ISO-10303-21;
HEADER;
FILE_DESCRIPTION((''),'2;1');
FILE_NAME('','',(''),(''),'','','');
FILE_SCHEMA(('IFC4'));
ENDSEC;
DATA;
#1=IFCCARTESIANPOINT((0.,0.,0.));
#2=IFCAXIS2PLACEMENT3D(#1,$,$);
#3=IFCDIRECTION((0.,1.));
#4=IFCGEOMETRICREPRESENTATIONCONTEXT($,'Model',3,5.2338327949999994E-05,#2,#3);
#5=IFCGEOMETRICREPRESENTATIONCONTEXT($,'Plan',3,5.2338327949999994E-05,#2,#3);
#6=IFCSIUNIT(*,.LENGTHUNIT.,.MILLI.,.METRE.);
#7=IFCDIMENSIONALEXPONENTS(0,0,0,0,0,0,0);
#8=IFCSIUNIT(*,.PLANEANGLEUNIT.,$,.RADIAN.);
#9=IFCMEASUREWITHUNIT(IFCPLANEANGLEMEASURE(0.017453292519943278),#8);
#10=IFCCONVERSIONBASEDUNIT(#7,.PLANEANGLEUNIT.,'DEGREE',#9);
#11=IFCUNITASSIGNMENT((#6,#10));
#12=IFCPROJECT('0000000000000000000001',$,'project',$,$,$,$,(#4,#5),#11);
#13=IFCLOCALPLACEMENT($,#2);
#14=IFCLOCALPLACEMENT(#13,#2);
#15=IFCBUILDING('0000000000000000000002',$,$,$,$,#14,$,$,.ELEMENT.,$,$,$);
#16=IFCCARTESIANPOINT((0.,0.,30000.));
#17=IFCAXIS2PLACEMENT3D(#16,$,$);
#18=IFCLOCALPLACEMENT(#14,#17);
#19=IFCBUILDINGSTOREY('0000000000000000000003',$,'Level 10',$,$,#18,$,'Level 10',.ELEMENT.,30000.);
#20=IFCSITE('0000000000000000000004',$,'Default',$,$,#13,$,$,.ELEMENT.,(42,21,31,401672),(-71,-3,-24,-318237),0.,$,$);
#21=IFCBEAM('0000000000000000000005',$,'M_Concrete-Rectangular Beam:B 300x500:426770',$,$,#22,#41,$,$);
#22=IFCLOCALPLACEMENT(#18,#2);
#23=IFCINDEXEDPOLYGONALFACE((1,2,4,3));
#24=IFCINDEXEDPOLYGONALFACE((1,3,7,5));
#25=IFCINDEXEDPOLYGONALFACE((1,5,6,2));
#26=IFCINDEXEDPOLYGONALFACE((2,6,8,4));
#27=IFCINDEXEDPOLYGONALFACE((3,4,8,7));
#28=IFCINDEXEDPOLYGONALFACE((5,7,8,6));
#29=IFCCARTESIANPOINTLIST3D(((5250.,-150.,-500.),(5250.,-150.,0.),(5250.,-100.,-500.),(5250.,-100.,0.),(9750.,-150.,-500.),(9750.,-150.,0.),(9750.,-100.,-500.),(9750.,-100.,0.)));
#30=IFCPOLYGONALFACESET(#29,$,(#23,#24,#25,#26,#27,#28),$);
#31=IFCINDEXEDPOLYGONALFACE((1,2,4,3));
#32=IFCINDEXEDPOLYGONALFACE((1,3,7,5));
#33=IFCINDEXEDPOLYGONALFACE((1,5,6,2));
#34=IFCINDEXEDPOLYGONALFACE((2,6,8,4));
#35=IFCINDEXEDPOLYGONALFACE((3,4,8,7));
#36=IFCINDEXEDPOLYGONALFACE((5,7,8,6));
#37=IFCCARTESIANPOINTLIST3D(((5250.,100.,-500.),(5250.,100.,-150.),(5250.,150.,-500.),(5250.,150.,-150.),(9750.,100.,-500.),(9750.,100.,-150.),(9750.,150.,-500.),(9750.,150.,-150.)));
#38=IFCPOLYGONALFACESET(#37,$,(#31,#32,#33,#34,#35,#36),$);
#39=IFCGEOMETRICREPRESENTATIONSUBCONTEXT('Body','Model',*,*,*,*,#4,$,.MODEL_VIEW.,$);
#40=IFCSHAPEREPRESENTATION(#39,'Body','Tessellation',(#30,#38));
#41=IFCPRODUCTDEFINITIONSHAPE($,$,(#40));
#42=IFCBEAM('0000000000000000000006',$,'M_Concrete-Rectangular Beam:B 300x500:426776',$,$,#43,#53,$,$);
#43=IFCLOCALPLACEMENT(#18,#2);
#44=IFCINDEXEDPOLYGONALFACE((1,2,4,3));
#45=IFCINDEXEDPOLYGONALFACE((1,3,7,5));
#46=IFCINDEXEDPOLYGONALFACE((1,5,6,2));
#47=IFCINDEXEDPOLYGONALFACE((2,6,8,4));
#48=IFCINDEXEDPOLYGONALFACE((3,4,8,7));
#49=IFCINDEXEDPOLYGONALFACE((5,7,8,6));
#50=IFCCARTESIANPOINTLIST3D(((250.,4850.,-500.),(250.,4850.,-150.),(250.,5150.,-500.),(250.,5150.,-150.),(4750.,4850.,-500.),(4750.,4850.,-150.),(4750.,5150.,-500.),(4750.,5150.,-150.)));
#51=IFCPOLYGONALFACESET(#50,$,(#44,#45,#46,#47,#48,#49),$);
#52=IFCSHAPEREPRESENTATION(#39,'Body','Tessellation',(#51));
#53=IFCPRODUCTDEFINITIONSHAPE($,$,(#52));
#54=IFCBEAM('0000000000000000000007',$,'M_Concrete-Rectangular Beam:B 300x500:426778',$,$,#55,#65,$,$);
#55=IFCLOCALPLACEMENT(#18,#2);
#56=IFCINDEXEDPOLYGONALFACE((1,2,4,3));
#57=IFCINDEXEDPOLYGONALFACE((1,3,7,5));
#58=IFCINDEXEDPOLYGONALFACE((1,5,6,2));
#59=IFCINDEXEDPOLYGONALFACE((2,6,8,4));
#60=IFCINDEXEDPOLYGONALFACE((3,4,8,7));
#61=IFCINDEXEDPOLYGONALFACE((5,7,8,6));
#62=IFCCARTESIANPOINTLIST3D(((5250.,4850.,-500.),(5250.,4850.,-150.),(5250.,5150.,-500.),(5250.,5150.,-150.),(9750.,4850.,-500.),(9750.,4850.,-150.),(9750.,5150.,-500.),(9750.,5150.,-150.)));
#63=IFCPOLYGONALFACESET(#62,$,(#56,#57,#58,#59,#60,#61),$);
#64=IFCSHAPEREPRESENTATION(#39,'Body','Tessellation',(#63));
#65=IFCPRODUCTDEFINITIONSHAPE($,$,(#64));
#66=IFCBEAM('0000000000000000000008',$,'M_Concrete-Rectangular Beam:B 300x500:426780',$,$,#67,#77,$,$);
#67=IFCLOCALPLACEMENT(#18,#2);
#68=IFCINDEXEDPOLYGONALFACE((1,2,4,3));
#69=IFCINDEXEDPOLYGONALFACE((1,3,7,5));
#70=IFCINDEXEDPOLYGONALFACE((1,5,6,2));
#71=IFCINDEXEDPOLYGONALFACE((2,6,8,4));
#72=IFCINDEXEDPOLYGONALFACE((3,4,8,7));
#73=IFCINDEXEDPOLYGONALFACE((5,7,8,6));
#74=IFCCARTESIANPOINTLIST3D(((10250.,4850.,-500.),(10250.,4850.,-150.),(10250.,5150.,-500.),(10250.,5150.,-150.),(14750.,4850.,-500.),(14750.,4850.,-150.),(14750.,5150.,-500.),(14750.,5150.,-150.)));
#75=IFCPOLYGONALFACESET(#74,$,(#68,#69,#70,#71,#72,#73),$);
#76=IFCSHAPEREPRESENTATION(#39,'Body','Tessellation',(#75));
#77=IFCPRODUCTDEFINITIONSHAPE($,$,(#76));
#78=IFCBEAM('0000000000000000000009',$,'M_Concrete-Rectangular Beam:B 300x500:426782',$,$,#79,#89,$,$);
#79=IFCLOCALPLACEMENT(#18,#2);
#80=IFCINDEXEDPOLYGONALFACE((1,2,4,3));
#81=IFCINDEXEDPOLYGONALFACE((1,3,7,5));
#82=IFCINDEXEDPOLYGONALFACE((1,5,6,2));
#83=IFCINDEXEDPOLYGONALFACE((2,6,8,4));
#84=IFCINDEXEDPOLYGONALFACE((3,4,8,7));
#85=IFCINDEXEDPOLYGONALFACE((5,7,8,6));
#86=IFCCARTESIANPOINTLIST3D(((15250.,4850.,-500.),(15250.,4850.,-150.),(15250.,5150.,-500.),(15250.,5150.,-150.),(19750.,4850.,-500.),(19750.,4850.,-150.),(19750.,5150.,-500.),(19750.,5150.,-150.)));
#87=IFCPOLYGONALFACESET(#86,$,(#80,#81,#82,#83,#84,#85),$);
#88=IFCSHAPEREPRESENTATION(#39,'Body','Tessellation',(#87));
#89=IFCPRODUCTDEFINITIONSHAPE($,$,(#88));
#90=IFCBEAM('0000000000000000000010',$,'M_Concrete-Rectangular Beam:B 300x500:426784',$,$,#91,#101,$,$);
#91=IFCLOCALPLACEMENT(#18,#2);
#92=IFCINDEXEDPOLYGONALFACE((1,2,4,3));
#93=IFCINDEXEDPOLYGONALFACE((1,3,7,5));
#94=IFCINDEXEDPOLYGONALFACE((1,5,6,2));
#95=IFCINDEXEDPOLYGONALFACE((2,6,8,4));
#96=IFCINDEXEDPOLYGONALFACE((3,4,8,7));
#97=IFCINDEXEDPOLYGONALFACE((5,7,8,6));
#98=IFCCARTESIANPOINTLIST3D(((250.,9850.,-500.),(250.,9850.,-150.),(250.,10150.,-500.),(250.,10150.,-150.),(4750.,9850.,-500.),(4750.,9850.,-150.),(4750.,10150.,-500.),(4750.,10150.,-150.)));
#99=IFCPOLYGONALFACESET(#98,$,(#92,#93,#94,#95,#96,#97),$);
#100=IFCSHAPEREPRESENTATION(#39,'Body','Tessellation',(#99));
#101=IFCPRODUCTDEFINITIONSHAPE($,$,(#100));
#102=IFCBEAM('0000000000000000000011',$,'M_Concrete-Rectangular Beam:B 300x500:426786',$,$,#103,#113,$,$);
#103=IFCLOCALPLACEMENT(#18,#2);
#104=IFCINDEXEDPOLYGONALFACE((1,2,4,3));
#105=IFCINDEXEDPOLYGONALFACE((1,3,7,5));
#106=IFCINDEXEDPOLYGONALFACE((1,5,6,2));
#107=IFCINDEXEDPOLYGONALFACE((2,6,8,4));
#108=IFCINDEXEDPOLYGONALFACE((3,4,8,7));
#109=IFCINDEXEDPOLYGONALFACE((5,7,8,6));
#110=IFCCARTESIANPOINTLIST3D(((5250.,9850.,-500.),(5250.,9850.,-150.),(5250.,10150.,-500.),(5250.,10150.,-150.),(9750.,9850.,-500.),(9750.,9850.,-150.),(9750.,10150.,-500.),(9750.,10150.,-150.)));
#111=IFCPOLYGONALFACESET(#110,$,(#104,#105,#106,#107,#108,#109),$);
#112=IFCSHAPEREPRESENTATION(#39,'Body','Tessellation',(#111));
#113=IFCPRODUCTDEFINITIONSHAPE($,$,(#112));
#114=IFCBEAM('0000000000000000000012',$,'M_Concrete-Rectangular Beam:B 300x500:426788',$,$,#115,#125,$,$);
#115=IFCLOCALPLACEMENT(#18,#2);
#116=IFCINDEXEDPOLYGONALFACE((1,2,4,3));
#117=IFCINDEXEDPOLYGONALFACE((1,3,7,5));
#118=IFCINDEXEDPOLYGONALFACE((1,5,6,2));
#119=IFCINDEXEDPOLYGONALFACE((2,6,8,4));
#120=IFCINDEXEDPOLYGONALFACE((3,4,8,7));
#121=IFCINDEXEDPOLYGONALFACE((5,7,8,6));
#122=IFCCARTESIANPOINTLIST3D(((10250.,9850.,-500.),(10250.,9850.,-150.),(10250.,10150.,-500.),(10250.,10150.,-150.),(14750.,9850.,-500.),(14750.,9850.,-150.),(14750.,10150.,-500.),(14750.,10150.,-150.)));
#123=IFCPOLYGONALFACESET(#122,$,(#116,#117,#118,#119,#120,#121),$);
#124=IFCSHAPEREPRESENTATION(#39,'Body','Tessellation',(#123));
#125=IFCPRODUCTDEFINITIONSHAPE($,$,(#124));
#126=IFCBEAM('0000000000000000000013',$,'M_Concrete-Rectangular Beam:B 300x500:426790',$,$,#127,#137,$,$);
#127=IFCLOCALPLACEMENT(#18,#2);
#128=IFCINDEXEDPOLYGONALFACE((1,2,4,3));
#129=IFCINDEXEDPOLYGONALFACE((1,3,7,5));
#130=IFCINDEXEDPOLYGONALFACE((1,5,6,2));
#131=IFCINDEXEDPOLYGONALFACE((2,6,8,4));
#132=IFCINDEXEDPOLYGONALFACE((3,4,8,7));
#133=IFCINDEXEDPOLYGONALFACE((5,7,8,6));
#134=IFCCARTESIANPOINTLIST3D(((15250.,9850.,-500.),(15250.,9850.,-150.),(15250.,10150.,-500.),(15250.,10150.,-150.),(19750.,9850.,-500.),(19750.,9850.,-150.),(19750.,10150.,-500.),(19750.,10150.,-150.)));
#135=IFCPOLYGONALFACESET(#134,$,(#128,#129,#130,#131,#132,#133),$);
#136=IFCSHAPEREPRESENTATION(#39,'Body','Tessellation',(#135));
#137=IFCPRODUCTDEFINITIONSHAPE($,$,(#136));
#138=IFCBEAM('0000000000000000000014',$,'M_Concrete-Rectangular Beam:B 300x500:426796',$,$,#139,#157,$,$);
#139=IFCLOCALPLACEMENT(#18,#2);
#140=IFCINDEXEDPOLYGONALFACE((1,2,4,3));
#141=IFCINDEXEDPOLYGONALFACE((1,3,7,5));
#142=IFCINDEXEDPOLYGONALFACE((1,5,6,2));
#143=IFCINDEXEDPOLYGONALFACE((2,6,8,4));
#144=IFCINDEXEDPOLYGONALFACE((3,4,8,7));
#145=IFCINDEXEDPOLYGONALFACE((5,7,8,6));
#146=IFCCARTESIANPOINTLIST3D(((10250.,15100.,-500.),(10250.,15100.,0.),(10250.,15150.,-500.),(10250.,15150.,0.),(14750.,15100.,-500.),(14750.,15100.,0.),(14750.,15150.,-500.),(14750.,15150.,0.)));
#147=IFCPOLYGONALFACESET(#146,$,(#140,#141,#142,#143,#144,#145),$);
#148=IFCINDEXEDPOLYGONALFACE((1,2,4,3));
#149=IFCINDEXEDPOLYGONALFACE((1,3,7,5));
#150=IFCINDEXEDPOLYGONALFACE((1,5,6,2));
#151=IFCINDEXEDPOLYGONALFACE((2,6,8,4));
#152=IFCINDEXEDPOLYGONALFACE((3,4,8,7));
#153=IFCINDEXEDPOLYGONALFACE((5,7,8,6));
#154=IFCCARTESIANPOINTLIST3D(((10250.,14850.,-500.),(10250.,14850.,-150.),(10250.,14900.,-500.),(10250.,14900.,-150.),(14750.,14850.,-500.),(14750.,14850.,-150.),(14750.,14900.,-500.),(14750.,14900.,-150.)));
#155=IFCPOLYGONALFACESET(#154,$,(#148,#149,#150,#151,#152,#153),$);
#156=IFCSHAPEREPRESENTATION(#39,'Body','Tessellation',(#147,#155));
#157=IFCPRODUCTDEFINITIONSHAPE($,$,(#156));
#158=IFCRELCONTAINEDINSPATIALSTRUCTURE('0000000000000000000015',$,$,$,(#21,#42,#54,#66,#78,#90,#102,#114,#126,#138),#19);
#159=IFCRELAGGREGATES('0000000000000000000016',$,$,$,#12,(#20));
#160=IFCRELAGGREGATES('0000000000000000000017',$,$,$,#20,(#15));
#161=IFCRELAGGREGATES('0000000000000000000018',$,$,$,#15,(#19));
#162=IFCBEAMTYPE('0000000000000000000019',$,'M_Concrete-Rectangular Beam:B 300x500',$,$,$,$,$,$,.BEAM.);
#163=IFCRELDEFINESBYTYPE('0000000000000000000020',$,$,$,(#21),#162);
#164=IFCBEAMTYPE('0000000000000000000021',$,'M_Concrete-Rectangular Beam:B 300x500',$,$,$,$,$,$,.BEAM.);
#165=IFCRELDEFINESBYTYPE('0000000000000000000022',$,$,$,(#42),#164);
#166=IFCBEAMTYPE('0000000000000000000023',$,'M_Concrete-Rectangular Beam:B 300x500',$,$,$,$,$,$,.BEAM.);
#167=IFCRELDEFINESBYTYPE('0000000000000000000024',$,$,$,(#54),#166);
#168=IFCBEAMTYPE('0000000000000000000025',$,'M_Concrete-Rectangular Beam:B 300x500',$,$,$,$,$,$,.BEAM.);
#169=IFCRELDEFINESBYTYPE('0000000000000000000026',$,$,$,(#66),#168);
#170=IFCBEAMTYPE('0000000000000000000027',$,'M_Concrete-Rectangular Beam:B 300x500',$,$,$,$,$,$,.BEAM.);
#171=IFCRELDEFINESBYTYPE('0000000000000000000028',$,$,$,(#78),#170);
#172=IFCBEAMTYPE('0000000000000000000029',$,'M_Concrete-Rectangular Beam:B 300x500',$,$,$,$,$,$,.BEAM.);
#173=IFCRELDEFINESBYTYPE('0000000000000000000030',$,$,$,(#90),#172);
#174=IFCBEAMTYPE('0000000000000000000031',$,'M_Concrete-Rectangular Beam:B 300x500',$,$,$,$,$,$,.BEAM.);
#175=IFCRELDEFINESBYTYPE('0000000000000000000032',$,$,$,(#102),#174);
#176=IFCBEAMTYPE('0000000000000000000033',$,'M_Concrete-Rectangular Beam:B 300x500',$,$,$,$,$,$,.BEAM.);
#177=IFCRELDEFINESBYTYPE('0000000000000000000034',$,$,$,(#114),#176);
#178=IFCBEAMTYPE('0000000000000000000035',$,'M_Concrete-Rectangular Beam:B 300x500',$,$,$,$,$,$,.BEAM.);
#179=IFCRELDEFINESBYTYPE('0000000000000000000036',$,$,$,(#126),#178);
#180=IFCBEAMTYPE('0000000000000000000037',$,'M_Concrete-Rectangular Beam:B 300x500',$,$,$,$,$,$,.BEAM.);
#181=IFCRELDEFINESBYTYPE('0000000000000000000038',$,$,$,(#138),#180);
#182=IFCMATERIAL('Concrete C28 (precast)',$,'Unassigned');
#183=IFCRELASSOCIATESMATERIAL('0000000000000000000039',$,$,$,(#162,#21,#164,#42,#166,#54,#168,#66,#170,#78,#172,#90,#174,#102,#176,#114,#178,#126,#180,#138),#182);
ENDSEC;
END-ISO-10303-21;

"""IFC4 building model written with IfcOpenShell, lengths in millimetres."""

from ifc_helpers import new_model, entity, si_unit, converted_unit, direction, frame, origin, place, context, subcontext, project, spatial, indexed_curve, outline, extrude, source, transform, mapped, material, type_object, type_shapes, element, save


model = new_model("IFC4")

# Units and contexts
model_context = context("Model", 3, precision=5.2338327949999994e-05, world=origin(), true_north=direction((0.0, 1.0)))
plan_context = context("Plan", 3, precision=5.2338327949999994e-05, world=origin(), true_north=direction((0.0, 1.0)))
body_context = subcontext(model_context, "Body", "Model", "MODEL_VIEW")
ifc_project = project(units=[si_unit("LENGTHUNIT", "METRE", prefix="MILLI"), converted_unit("PLANEANGLEUNIT", "DEGREE", entity("IfcPlaneAngleMeasure", 0.017453292519943278), si_unit("PLANEANGLEUNIT", "RADIAN"), dimensions=[0, 0, 0, 0, 0, 0, 0])], contexts=[model_context, plan_context])

# Site, building, storey
site_placement = place(None, origin())
site = spatial("IfcSite", under=ifc_project, at=site_placement, Name="Default", CompositionType="ELEMENT", RefLatitude=(42, 21, 31, 401672), RefLongitude=(-71, -3, -24, -318237), RefElevation=0.0)
building_placement = place(site_placement, origin())
building = spatial("IfcBuilding", under=site, at=building_placement, CompositionType="ELEMENT")
storey_placement = place(building_placement, frame((0.0, 0.0, 30000.0)))
storey = spatial("IfcBuildingStorey", under=building, at=storey_placement, Name="Level 10", LongName="Level 10", CompositionType="ELEMENT", Elevation=30000.0)

# Beams
ifc_material = material(Name="Concrete C28 (precast)", Category="Unassigned")
beam_type_1 = type_object("IfcBeamType", Name="M_Concrete-Rectangular Beam:B 300x500", PredefinedType="BEAM", material=ifc_material)
shared_shape_1 = source(origin(), body_context, "Body", "SweptSolid", [
    extrude(outline(indexed_curve([(-250.0, -25.0), (250.0, -25.0), (250.0, 25.0), (-250.0, 25.0), (-250.0, -25.0)], self_intersect=False)), frame((5250.0, -125.0, 29750.0), z_axis=(1.0, 0.0, 0.0), x_axis=(0.0, 0.0, -1.0)), (0.0, 0.0, 1.0), 4500.0),
    extrude(outline(indexed_curve([(-175.0, -25.0), (175.0, -25.0), (175.0, 25.0), (-175.0, 25.0), (-175.0, -25.0)], self_intersect=False)), frame((5250.0, 125.0, 29675.0), z_axis=(1.0, 0.0, 0.0), x_axis=(0.0, 0.0, -1.0)), (0.0, 0.0, 1.0), 4500.0),
])
type_shapes(beam_type_1, [shared_shape_1])
beam_1_placement = place(storey_placement, frame((0.0, 0.0, -30000.0)))
element("IfcBeam", 1, at=beam_1_placement, inside=storey, type_object=beam_type_1, material=ifc_material, Name="M_Concrete-Rectangular Beam:B 300x500:426770", context=body_context, shape_type="MappedRepresentation", body=[
    mapped(shared_shape_1, transform((0.0, 0.0, 0.0), scale=1.0)),
])
beam_type_2 = type_object("IfcBeamType", Name="M_Concrete-Rectangular Beam:B 300x500", PredefinedType="BEAM", material=ifc_material)
shared_shape_2 = source(origin(), body_context, "Body", "SweptSolid", [
    extrude(outline(indexed_curve([(-175.0, -150.0), (175.0, -150.0), (175.0, 150.0), (-175.0, 150.0), (-175.0, -150.0)], self_intersect=False)), frame((250.0, 5000.0, 29675.0), z_axis=(1.0, 0.0, 0.0), x_axis=(0.0, 0.0, -1.0)), (0.0, 0.0, 1.0), 4500.0),
])
type_shapes(beam_type_2, [shared_shape_2])
beam_2_placement = place(storey_placement, frame((0.0, 0.0, -30000.0)))
element("IfcBeam", 2, at=beam_2_placement, inside=storey, type_object=beam_type_2, material=ifc_material, Name="M_Concrete-Rectangular Beam:B 300x500:426776", context=body_context, shape_type="MappedRepresentation", body=[
    mapped(shared_shape_2, transform((0.0, 0.0, 0.0), scale=1.0)),
])
beam_type_3 = type_object("IfcBeamType", Name="M_Concrete-Rectangular Beam:B 300x500", PredefinedType="BEAM", material=ifc_material)
shared_shape_3 = source(origin(), body_context, "Body", "SweptSolid", [
    extrude(outline(indexed_curve([(-175.0, -150.0), (175.0, -150.0), (175.0, 150.0), (-175.0, 150.0), (-175.0, -150.0)], self_intersect=False)), frame((5250.0, 5000.0, 29675.0), z_axis=(1.0, 0.0, 0.0), x_axis=(0.0, 0.0, -1.0)), (0.0, 0.0, 1.0), 4500.0),
])
type_shapes(beam_type_3, [shared_shape_3])
beam_3_placement = place(storey_placement, frame((0.0, 0.0, -30000.0)))
element("IfcBeam", 3, at=beam_3_placement, inside=storey, type_object=beam_type_3, material=ifc_material, Name="M_Concrete-Rectangular Beam:B 300x500:426778", context=body_context, shape_type="MappedRepresentation", body=[
    mapped(shared_shape_3, transform((0.0, 0.0, 0.0), scale=1.0)),
])
beam_type_4 = type_object("IfcBeamType", Name="M_Concrete-Rectangular Beam:B 300x500", PredefinedType="BEAM", material=ifc_material)
shared_shape_4 = source(origin(), body_context, "Body", "SweptSolid", [
    extrude(outline(indexed_curve([(-175.0, -150.0), (175.0, -150.0), (175.0, 150.0), (-175.0, 150.0), (-175.0, -150.0)], self_intersect=False)), frame((10250.0, 5000.0, 29675.0), z_axis=(1.0, 0.0, 0.0), x_axis=(0.0, 0.0, -1.0)), (0.0, 0.0, 1.0), 4500.0),
])
type_shapes(beam_type_4, [shared_shape_4])
beam_4_placement = place(storey_placement, frame((0.0, 0.0, -30000.0)))
element("IfcBeam", 4, at=beam_4_placement, inside=storey, type_object=beam_type_4, material=ifc_material, Name="M_Concrete-Rectangular Beam:B 300x500:426780", context=body_context, shape_type="MappedRepresentation", body=[
    mapped(shared_shape_4, transform((0.0, 0.0, 0.0), scale=1.0)),
])
beam_type_5 = type_object("IfcBeamType", Name="M_Concrete-Rectangular Beam:B 300x500", PredefinedType="BEAM", material=ifc_material)
shared_shape_5 = source(origin(), body_context, "Body", "SweptSolid", [
    extrude(outline(indexed_curve([(-175.0, -150.0), (175.0, -150.0), (175.0, 150.0), (-175.0, 150.0), (-175.0, -150.0)], self_intersect=False)), frame((15250.0, 5000.0, 29675.0), z_axis=(1.0, 0.0, 0.0), x_axis=(0.0, 0.0, -1.0)), (0.0, 0.0, 1.0), 4500.0),
])
type_shapes(beam_type_5, [shared_shape_5])
beam_5_placement = place(storey_placement, frame((0.0, 0.0, -30000.0)))
element("IfcBeam", 5, at=beam_5_placement, inside=storey, type_object=beam_type_5, material=ifc_material, Name="M_Concrete-Rectangular Beam:B 300x500:426782", context=body_context, shape_type="MappedRepresentation", body=[
    mapped(shared_shape_5, transform((0.0, 0.0, 0.0), scale=1.0)),
])
beam_type_6 = type_object("IfcBeamType", Name="M_Concrete-Rectangular Beam:B 300x500", PredefinedType="BEAM", material=ifc_material)
shared_shape_6 = source(origin(), body_context, "Body", "SweptSolid", [
    extrude(outline(indexed_curve([(-175.0, -150.0), (175.0, -150.0), (175.0, 150.0), (-175.0, 150.0), (-175.0, -150.0)], self_intersect=False)), frame((250.0, 10000.0, 29675.0), z_axis=(1.0, 0.0, 0.0), x_axis=(0.0, 0.0, -1.0)), (0.0, 0.0, 1.0), 4500.0),
])
type_shapes(beam_type_6, [shared_shape_6])
beam_6_placement = place(storey_placement, frame((0.0, 0.0, -30000.0)))
element("IfcBeam", 6, at=beam_6_placement, inside=storey, type_object=beam_type_6, material=ifc_material, Name="M_Concrete-Rectangular Beam:B 300x500:426784", context=body_context, shape_type="MappedRepresentation", body=[
    mapped(shared_shape_6, transform((0.0, 0.0, 0.0), scale=1.0)),
])
beam_type_7 = type_object("IfcBeamType", Name="M_Concrete-Rectangular Beam:B 300x500", PredefinedType="BEAM", material=ifc_material)
shared_shape_7 = source(origin(), body_context, "Body", "SweptSolid", [
    extrude(outline(indexed_curve([(-175.0, -150.0), (175.0, -150.0), (175.0, 150.0), (-175.0, 150.0), (-175.0, -150.0)], self_intersect=False)), frame((5250.0, 10000.0, 29675.0), z_axis=(1.0, 0.0, 0.0), x_axis=(0.0, 0.0, -1.0)), (0.0, 0.0, 1.0), 4500.0),
])
type_shapes(beam_type_7, [shared_shape_7])
beam_7_placement = place(storey_placement, frame((0.0, 0.0, -30000.0)))
element("IfcBeam", 7, at=beam_7_placement, inside=storey, type_object=beam_type_7, material=ifc_material, Name="M_Concrete-Rectangular Beam:B 300x500:426786", context=body_context, shape_type="MappedRepresentation", body=[
    mapped(shared_shape_7, transform((0.0, 0.0, 0.0), scale=1.0)),
])
beam_type_8 = type_object("IfcBeamType", Name="M_Concrete-Rectangular Beam:B 300x500", PredefinedType="BEAM", material=ifc_material)
shared_shape_8 = source(origin(), body_context, "Body", "SweptSolid", [
    extrude(outline(indexed_curve([(-175.0, -150.0), (175.0, -150.0), (175.0, 150.0), (-175.0, 150.0), (-175.0, -150.0)], self_intersect=False)), frame((10250.0, 10000.0, 29675.0), z_axis=(1.0, 0.0, 0.0), x_axis=(0.0, 0.0, -1.0)), (0.0, 0.0, 1.0), 4500.0),
])
type_shapes(beam_type_8, [shared_shape_8])
beam_8_placement = place(storey_placement, frame((0.0, 0.0, -30000.0)))
element("IfcBeam", 8, at=beam_8_placement, inside=storey, type_object=beam_type_8, material=ifc_material, Name="M_Concrete-Rectangular Beam:B 300x500:426788", context=body_context, shape_type="MappedRepresentation", body=[
    mapped(shared_shape_8, transform((0.0, 0.0, 0.0), scale=1.0)),
])
beam_type_9 = type_object("IfcBeamType", Name="M_Concrete-Rectangular Beam:B 300x500", PredefinedType="BEAM", material=ifc_material)
shared_shape_9 = source(origin(), body_context, "Body", "SweptSolid", [
    extrude(outline(indexed_curve([(-175.0, -150.0), (175.0, -150.0), (175.0, 150.0), (-175.0, 150.0), (-175.0, -150.0)], self_intersect=False)), frame((15250.0, 10000.0, 29675.0), z_axis=(1.0, 0.0, 0.0), x_axis=(0.0, 0.0, -1.0)), (0.0, 0.0, 1.0), 4500.0),
])
type_shapes(beam_type_9, [shared_shape_9])
beam_9_placement = place(storey_placement, frame((0.0, 0.0, -30000.0)))
element("IfcBeam", 9, at=beam_9_placement, inside=storey, type_object=beam_type_9, material=ifc_material, Name="M_Concrete-Rectangular Beam:B 300x500:426790", context=body_context, shape_type="MappedRepresentation", body=[
    mapped(shared_shape_9, transform((0.0, 0.0, 0.0), scale=1.0)),
])
beam_type_10 = type_object("IfcBeamType", Name="M_Concrete-Rectangular Beam:B 300x500", PredefinedType="BEAM", material=ifc_material)
shared_shape_10 = source(origin(), body_context, "Body", "SweptSolid", [
    extrude(outline(indexed_curve([(-250.0, -25.0), (250.0, -25.0), (250.0, 25.0), (-250.0, 25.0), (-250.0, -25.0)], self_intersect=False)), frame((10250.0, 15125.0, 29750.0), z_axis=(1.0, 0.0, 0.0), x_axis=(0.0, 0.0, -1.0)), (0.0, 0.0, 1.0), 4500.0),
    extrude(outline(indexed_curve([(-175.0, -25.0), (175.0, -25.0), (175.0, 25.0), (-175.0, 25.0), (-175.0, -25.0)], self_intersect=False)), frame((10250.0, 14875.0, 29675.0), z_axis=(1.0, 0.0, 0.0), x_axis=(0.0, 0.0, -1.0)), (0.0, 0.0, 1.0), 4500.0),
])
type_shapes(beam_type_10, [shared_shape_10])
beam_10_placement = place(storey_placement, frame((0.0, 0.0, -30000.0)))
element("IfcBeam", 10, at=beam_10_placement, inside=storey, type_object=beam_type_10, material=ifc_material, Name="M_Concrete-Rectangular Beam:B 300x500:426796", context=body_context, shape_type="MappedRepresentation", body=[
    mapped(shared_shape_10, transform((0.0, 0.0, 0.0), scale=1.0)),
])

save(model, "model.ifc")
